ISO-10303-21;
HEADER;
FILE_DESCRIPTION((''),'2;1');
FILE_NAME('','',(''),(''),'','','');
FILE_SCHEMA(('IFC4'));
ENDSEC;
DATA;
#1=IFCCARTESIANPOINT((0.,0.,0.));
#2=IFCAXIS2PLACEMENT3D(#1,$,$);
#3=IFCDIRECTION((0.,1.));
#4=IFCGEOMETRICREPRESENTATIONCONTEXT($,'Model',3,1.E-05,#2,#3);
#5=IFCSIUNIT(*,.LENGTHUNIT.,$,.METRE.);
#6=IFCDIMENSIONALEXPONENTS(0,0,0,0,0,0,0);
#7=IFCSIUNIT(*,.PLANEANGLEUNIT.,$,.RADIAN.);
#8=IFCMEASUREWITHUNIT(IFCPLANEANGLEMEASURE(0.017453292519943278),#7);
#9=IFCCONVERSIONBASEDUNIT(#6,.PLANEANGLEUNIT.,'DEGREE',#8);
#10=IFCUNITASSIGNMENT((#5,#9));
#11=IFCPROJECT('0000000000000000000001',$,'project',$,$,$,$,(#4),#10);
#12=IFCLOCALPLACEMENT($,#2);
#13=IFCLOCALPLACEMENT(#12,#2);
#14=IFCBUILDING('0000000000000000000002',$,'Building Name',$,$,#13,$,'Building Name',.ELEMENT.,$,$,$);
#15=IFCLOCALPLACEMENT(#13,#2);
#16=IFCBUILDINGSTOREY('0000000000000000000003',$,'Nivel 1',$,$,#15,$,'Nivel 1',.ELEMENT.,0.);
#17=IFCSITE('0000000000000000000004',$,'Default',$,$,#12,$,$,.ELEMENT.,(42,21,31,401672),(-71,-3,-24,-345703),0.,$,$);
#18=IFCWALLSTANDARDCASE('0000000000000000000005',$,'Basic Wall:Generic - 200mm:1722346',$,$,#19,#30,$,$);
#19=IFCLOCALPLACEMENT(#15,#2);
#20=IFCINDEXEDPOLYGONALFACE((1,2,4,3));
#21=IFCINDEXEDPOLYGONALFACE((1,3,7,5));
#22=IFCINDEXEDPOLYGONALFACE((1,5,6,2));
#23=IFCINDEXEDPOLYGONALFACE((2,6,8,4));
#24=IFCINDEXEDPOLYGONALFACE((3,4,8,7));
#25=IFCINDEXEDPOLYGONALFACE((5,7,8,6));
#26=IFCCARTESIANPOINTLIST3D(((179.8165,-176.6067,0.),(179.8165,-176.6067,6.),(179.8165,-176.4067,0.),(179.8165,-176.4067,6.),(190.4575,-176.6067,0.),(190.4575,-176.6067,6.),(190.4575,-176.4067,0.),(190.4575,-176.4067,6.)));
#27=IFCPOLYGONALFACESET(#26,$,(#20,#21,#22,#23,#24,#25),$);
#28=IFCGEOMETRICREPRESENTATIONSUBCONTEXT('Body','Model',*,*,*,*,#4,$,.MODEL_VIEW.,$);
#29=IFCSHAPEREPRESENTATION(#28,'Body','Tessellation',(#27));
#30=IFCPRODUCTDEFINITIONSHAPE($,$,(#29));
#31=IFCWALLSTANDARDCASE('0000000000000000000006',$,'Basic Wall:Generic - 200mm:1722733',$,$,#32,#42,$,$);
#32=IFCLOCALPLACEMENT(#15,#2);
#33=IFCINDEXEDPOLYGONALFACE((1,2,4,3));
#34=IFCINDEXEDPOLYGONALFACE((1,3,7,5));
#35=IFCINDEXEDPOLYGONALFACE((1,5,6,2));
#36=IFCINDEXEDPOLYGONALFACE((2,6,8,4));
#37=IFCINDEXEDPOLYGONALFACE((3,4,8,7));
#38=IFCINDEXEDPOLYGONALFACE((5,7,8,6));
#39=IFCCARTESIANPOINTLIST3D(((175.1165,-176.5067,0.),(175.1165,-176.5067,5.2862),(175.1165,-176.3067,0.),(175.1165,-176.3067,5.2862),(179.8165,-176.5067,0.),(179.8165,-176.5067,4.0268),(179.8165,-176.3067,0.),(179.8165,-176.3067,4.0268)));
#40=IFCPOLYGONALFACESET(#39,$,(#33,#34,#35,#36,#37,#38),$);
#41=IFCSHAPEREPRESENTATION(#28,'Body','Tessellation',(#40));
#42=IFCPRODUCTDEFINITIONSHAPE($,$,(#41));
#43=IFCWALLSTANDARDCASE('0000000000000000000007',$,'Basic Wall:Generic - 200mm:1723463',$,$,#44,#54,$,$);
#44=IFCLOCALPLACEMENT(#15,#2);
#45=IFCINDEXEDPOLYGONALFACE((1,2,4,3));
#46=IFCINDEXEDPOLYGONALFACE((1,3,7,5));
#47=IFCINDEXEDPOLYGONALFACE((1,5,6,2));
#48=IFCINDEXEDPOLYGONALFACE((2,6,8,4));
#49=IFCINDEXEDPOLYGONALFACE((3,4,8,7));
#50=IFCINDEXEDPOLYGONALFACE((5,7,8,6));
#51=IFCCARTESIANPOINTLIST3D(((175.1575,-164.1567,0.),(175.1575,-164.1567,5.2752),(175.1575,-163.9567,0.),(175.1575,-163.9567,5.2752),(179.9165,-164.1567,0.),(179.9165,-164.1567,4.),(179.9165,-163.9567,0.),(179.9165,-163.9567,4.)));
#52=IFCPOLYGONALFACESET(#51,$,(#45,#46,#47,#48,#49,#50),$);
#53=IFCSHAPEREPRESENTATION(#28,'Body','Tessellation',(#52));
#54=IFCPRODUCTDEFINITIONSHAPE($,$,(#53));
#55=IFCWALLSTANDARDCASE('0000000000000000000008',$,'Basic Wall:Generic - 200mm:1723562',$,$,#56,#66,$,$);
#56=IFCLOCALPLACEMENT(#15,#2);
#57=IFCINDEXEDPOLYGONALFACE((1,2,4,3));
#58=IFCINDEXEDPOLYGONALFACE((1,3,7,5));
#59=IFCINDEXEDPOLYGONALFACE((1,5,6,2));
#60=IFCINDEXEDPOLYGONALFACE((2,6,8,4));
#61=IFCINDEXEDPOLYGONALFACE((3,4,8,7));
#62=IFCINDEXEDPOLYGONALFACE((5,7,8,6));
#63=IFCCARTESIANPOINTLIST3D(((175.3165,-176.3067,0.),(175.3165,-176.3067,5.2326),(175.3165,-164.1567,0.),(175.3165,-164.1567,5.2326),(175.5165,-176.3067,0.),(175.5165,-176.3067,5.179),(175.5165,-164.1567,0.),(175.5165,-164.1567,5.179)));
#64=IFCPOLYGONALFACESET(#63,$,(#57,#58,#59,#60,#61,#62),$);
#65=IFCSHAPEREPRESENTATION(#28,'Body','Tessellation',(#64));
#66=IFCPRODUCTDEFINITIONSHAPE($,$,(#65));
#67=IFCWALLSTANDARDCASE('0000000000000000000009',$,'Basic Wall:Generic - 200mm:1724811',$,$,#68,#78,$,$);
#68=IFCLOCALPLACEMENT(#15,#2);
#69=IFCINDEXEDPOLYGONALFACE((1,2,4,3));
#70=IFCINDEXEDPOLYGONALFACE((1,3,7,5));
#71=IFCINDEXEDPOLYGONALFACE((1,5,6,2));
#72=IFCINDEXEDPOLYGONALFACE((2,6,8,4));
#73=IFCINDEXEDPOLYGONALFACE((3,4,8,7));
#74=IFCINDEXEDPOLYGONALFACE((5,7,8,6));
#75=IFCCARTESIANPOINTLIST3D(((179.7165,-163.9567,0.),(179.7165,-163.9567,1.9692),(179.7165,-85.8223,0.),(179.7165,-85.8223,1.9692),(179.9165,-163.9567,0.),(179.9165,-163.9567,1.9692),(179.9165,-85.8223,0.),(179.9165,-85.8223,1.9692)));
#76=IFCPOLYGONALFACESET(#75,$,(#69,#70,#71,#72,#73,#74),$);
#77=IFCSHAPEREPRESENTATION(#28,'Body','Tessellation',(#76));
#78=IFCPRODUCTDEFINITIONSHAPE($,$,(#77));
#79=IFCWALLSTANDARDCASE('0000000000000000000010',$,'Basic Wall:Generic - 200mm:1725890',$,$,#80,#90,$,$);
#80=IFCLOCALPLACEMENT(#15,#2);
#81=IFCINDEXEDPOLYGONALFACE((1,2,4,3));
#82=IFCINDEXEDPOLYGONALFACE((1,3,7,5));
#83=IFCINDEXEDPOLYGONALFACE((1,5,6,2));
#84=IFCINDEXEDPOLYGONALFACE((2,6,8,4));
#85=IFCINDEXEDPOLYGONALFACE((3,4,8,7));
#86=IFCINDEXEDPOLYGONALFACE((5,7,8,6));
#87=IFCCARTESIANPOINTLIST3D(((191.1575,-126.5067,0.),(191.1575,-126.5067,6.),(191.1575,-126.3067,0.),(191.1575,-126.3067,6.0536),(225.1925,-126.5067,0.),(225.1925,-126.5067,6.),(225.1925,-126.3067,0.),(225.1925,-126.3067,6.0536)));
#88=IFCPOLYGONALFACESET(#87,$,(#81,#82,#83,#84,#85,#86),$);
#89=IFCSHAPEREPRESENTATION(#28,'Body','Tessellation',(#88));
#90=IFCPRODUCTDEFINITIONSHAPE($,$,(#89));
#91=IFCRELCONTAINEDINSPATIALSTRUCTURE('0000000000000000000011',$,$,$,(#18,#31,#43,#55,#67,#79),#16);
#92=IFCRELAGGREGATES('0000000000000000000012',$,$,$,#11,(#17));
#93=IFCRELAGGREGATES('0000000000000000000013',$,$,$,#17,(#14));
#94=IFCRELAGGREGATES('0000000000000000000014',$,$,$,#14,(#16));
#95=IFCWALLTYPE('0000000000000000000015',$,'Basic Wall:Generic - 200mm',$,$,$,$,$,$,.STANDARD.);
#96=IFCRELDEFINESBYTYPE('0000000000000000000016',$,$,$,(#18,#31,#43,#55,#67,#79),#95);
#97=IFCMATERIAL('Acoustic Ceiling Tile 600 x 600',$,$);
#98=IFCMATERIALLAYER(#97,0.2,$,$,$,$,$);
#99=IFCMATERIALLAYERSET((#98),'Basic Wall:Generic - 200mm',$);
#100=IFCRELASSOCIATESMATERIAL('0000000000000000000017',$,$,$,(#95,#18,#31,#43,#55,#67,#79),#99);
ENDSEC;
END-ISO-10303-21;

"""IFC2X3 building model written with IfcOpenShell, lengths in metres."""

from ifc_helpers import new_model, entity, si_unit, converted_unit, direction, frame, frame_2d, origin, place, context, subcontext, project, spatial, polyline, rectangle, extrude, clip, bounded_halfspace, material, layer, layer_set, layer_usage, type_object, element, save


model = new_model("IFC2X3")

# Units and contexts
model_context = context("Model", 3, precision=1e-05, world=origin(), true_north=direction((0.0, 1.0)))
body_context = subcontext(model_context, "Body", "Model", "MODEL_VIEW")
ifc_project = project(units=[si_unit("LENGTHUNIT", "METRE"), converted_unit("PLANEANGLEUNIT", "DEGREE", entity("IfcPlaneAngleMeasure", 0.017453292519943278), si_unit("PLANEANGLEUNIT", "RADIAN"), dimensions=[0, 0, 0, 0, 0, 0, 0])], contexts=[model_context])

# Site, building, storey
site_placement = place(None, origin())
site = spatial("IfcSite", under=ifc_project, at=site_placement, Name="Default", CompositionType="ELEMENT", RefLatitude=(42, 21, 31, 401672), RefLongitude=(-71, -3, -24, -345703), RefElevation=0.0)
building_placement = place(site_placement, origin())
building = spatial("IfcBuilding", under=site, at=building_placement, Name="Building Name", LongName="Building Name", CompositionType="ELEMENT")
storey_placement = place(building_placement, origin())
storey = spatial("IfcBuildingStorey", under=building, at=storey_placement, Name="Nivel 1", LongName="Nivel 1", CompositionType="ELEMENT", Elevation=0.0)

# Walls
ifc_material_1 = material(Name="Acoustic Ceiling Tile 600 x 600")
ifc_layer = layer(ifc_material_1, 0.2)
ifc_layer_set = layer_set([ifc_layer], Name="Basic Wall:Generic - 200mm")
wall_type_1 = type_object("IfcWallType", Name="Basic Wall:Generic - 200mm", PredefinedType="STANDARD", material=ifc_layer_set)
ifc_layer_usage_1 = layer_usage(ifc_layer_set, "AXIS2", "NEGATIVE", 0.1)
wall_1_placement = place(storey_placement, frame((179.8165, -176.5067, 0.0)))
element("IfcWallStandardCase", 1, at=wall_1_placement, inside=storey, type_object=wall_type_1, material=ifc_layer_usage_1, Name="Basic Wall:Generic - 200mm:1722346", context=body_context, shape_type="SweptSolid", body=[
    extrude(rectangle(XDim=10.641, YDim=0.2, at=frame_2d((5.3205, 0.0), x_axis=(-1.0, 0.0))), origin(), (0.0, 0.0, 1.0), 6.0),
])
ifc_layer_usage_2 = layer_usage(ifc_layer_set, "AXIS2", "NEGATIVE", 0.1)
wall_2_placement = place(storey_placement, frame((179.8165, -176.4067, 0.0), z_axis=(0.0, 0.0, 1.0), x_axis=(-1.0, 0.0, 0.0)))
element("IfcWallStandardCase", 2, at=wall_2_placement, inside=storey, type_object=wall_type_1, material=ifc_layer_usage_2, Name="Basic Wall:Generic - 200mm:1722733", context=body_context, shape_type="Clipping", body=[
    clip(extrude(rectangle(XDim=4.7, YDim=0.2, at=frame_2d((2.35, 0.0), x_axis=(-1.0, 0.0))), origin(), (0.0, 0.0, 1.0), 5.2862), bounded_halfspace(frame((0.0, -0.1, 4.0268), z_axis=(-0.258819, 0.0, 0.965926), x_axis=(0.0, -1.0, 0.0)), False, frame((0.0, -0.1, 4.0268)), polyline([(0.0, 0.0), (4.3, 0.0), (4.5, 0.0), (4.7, 0.0), (4.7, 0.2), (0.0, 0.2), (0.0, 0.0)]))),
])
ifc_layer_usage_3 = layer_usage(ifc_layer_set, "AXIS2", "NEGATIVE", 0.1)
wall_3_placement = place(storey_placement, frame((179.9165, -164.0567, 0.0), z_axis=(0.0, 0.0, 1.0), x_axis=(-1.0, 0.0, 0.0)))
element("IfcWallStandardCase", 3, at=wall_3_placement, inside=storey, type_object=wall_type_1, material=ifc_layer_usage_3, Name="Basic Wall:Generic - 200mm:1723463", context=body_context, shape_type="Clipping", body=[
    clip(extrude(rectangle(XDim=4.759, YDim=0.2, at=frame_2d((2.3795, 0.0), x_axis=(-1.0, 0.0))), origin(), (0.0, 0.0, 1.0), 5.2752), bounded_halfspace(frame((0.0, -0.1, 4.0), z_axis=(-0.258819, 0.0, 0.965926), x_axis=(0.0, -1.0, 0.0)), False, frame((0.0, -0.1, 4.0)), polyline([(0.0, 0.0), (4.759, 0.0), (4.759, 0.2), (4.6, 0.2), (4.4, 0.2), (0.0, 0.2), (0.0, 0.0)]))),
])
ifc_layer_usage_4 = layer_usage(ifc_layer_set, "AXIS2", "NEGATIVE", 0.1)
wall_4_placement = place(storey_placement, frame((175.4165, -176.3067, 0.0), z_axis=(0.0, 0.0, 1.0), x_axis=(0.0, 1.0, 0.0)))
element("IfcWallStandardCase", 4, at=wall_4_placement, inside=storey, type_object=wall_type_1, material=ifc_layer_usage_4, Name="Basic Wall:Generic - 200mm:1723562", context=body_context, shape_type="Clipping", body=[
    clip(extrude(rectangle(XDim=12.15, YDim=0.2, at=frame_2d((6.075, 0.0), x_axis=(-1.0, 0.0))), origin(), (0.0, 0.0, 1.0), 5.2326), bounded_halfspace(frame((0.0, -0.1, 5.179), z_axis=(0.0, -0.258819, 0.965926), x_axis=(1.0, 0.0, 0.0)), False, frame((0.0, -0.1, 5.179)), polyline([(0.0, 0.0), (12.15, 0.0), (12.15, 0.2), (0.0, 0.2), (0.0, 0.0)]))),
])
ifc_layer_usage_5 = layer_usage(ifc_layer_set, "AXIS2", "NEGATIVE", 0.1)
wall_5_placement = place(storey_placement, frame((179.8165, -163.9567, 0.0), z_axis=(0.0, 0.0, 1.0), x_axis=(0.0, 1.0, 0.0)))
element("IfcWallStandardCase", 5, at=wall_5_placement, inside=storey, type_object=wall_type_1, material=ifc_layer_usage_5, Name="Basic Wall:Generic - 200mm:1724811", context=body_context, shape_type="SweptSolid", body=[
    extrude(rectangle(XDim=78.1344, YDim=0.2, at=frame_2d((39.0672, 0.0), x_axis=(-1.0, 0.0))), origin(), (0.0, 0.0, 1.0), 1.9692),
])
ifc_layer_usage_6 = layer_usage(ifc_layer_set, "AXIS2", "NEGATIVE", 0.1)
wall_6_placement = place(storey_placement, frame((191.1575, -126.4067, 0.0)))
element("IfcWallStandardCase", 6, at=wall_6_placement, inside=storey, type_object=wall_type_1, material=ifc_layer_usage_6, Name="Basic Wall:Generic - 200mm:1725890", context=body_context, shape_type="Clipping", body=[
    clip(extrude(rectangle(XDim=34.035, YDim=0.2, at=frame_2d((17.0175, 0.0), x_axis=(-1.0, 0.0))), origin(), (0.0, 0.0, 1.0), 6.0536), bounded_halfspace(frame((0.0, -0.1, 6.0), z_axis=(0.0, -0.258819, 0.965926), x_axis=(1.0, 0.0, 0.0)), False, frame((0.0, -0.1, 6.0)), polyline([(0.0, 0.0), (34.035, 0.0), (34.035, 0.2), (0.0, 0.2), (0.0, 0.0)]))),
])

save(model, "model.ifc")
